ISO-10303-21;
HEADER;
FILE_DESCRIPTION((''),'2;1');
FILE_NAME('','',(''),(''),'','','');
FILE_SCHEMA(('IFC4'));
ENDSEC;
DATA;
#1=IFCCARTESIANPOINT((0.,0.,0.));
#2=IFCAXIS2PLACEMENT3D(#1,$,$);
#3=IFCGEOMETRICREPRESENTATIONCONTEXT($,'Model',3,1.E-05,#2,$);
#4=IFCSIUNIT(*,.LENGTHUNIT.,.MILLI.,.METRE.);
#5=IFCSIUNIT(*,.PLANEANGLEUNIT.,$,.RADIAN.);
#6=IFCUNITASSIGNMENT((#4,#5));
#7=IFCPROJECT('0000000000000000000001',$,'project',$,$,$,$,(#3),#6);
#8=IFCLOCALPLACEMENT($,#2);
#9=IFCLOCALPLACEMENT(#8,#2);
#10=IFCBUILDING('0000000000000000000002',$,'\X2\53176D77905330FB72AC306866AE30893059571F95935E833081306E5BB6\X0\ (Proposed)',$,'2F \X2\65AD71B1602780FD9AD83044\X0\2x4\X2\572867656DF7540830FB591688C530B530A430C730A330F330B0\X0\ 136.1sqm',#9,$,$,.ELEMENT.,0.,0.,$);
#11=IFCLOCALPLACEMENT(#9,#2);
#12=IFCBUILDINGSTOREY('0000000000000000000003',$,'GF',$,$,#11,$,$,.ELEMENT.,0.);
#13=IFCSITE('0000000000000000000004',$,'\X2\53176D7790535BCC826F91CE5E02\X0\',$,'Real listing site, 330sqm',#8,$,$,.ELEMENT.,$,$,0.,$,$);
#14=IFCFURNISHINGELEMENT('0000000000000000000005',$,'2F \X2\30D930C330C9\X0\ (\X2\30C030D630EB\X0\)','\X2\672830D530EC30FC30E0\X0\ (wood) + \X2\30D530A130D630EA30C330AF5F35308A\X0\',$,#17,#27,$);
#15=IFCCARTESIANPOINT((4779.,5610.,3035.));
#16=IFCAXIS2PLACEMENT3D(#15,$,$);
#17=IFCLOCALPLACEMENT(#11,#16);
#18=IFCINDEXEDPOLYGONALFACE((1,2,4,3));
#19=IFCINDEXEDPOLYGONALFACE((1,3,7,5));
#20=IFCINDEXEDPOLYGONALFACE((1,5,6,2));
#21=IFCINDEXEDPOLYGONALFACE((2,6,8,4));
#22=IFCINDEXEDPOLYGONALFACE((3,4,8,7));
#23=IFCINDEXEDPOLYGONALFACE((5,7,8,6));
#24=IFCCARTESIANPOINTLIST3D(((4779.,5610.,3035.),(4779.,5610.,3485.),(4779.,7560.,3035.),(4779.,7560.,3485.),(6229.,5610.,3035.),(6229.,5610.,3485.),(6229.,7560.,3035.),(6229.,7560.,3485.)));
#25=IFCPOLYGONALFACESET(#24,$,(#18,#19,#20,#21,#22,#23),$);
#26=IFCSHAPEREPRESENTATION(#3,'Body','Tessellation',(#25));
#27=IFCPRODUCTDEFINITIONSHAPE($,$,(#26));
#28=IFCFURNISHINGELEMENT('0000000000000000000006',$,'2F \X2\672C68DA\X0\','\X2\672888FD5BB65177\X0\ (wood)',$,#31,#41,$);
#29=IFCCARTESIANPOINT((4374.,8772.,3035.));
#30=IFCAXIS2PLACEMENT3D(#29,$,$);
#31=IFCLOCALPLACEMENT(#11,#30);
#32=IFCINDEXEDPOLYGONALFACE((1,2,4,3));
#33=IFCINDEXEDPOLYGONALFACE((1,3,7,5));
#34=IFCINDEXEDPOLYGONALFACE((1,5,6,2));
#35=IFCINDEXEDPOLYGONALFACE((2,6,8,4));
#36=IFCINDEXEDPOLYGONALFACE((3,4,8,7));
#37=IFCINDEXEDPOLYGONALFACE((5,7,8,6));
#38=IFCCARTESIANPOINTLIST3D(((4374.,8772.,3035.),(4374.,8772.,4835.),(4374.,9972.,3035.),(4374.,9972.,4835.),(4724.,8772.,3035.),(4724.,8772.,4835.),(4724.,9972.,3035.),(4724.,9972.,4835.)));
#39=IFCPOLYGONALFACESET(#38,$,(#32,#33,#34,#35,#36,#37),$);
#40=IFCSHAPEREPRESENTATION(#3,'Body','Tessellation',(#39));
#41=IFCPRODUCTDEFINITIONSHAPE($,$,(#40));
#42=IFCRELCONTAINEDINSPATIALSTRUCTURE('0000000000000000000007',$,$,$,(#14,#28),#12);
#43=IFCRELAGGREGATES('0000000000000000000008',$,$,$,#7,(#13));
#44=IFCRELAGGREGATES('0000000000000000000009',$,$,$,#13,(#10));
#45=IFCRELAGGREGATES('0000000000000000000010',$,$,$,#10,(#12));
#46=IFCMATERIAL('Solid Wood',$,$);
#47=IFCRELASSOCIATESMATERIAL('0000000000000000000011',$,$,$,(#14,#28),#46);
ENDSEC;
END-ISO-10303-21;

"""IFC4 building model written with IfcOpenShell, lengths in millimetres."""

from ifc_helpers import new_model, si_unit, frame, frame_2d, origin, place, context, project, spatial, rectangle, extrude, material, element, save


model = new_model("IFC4")

# Units and contexts
model_context = context("Model", 3, precision=1e-05, world=origin())
ifc_project = project(units=[si_unit("LENGTHUNIT", "METRE", prefix="MILLI"), si_unit("PLANEANGLEUNIT", "RADIAN")], contexts=[model_context])

# Site, building, storey
site_placement = place(None, origin())
site = spatial("IfcSite", under=ifc_project, at=site_placement, Name="北海道富良野市", ObjectType="Real listing site, 330sqm", CompositionType="ELEMENT", RefElevation=0.0)
building_placement = place(site_placement, origin())
building = spatial("IfcBuilding", under=site, at=building_placement, Name="北海道・犬と暮らす土間広めの家 (Proposed)", ObjectType="2F 断熱性能高い2x4在来混合・外装サイディング 136.1sqm", CompositionType="ELEMENT", ElevationOfRefHeight=0.0, ElevationOfTerrain=0.0)
storey_placement = place(building_placement, origin())
storey = spatial("IfcBuildingStorey", under=building, at=storey_placement, Name="GF", CompositionType="ELEMENT", Elevation=0.0)

# Shared definitions
ifc_material_1 = material(Name="Solid Wood")

# Furnishing elements
furnishing_1_placement = place(storey_placement, frame((4779.0, 5610.0, 3035.0)))
element("IfcFurnishingElement", 1, at=furnishing_1_placement, inside=storey, material=ifc_material_1, Name="2F ベッド (ダブル)", Description="木フレーム (wood) + ファブリック張り", context=model_context, shape_type="SweptSolid", body=[
    extrude(rectangle(XDim=1450.0, YDim=1950.0, at=frame_2d((725.0, 975.0))), frame((4779.0, 5610.0, 3035.0)), (0.0, 0.0, 1.0), 450.0),
])
furnishing_2_placement = place(storey_placement, frame((4374.0, 8772.0, 3035.0)))
element("IfcFurnishingElement", 2, at=furnishing_2_placement, inside=storey, material=ifc_material_1, Name="2F 本棚", Description="木製家具 (wood)", context=model_context, shape_type="SweptSolid", body=[
    extrude(rectangle(XDim=350.0, YDim=1200.0, at=frame_2d((175.0, 600.0))), frame((4374.0, 8772.0, 3035.0)), (0.0, 0.0, 1.0), 1800.0),
])

save(model, "model.ifc")
